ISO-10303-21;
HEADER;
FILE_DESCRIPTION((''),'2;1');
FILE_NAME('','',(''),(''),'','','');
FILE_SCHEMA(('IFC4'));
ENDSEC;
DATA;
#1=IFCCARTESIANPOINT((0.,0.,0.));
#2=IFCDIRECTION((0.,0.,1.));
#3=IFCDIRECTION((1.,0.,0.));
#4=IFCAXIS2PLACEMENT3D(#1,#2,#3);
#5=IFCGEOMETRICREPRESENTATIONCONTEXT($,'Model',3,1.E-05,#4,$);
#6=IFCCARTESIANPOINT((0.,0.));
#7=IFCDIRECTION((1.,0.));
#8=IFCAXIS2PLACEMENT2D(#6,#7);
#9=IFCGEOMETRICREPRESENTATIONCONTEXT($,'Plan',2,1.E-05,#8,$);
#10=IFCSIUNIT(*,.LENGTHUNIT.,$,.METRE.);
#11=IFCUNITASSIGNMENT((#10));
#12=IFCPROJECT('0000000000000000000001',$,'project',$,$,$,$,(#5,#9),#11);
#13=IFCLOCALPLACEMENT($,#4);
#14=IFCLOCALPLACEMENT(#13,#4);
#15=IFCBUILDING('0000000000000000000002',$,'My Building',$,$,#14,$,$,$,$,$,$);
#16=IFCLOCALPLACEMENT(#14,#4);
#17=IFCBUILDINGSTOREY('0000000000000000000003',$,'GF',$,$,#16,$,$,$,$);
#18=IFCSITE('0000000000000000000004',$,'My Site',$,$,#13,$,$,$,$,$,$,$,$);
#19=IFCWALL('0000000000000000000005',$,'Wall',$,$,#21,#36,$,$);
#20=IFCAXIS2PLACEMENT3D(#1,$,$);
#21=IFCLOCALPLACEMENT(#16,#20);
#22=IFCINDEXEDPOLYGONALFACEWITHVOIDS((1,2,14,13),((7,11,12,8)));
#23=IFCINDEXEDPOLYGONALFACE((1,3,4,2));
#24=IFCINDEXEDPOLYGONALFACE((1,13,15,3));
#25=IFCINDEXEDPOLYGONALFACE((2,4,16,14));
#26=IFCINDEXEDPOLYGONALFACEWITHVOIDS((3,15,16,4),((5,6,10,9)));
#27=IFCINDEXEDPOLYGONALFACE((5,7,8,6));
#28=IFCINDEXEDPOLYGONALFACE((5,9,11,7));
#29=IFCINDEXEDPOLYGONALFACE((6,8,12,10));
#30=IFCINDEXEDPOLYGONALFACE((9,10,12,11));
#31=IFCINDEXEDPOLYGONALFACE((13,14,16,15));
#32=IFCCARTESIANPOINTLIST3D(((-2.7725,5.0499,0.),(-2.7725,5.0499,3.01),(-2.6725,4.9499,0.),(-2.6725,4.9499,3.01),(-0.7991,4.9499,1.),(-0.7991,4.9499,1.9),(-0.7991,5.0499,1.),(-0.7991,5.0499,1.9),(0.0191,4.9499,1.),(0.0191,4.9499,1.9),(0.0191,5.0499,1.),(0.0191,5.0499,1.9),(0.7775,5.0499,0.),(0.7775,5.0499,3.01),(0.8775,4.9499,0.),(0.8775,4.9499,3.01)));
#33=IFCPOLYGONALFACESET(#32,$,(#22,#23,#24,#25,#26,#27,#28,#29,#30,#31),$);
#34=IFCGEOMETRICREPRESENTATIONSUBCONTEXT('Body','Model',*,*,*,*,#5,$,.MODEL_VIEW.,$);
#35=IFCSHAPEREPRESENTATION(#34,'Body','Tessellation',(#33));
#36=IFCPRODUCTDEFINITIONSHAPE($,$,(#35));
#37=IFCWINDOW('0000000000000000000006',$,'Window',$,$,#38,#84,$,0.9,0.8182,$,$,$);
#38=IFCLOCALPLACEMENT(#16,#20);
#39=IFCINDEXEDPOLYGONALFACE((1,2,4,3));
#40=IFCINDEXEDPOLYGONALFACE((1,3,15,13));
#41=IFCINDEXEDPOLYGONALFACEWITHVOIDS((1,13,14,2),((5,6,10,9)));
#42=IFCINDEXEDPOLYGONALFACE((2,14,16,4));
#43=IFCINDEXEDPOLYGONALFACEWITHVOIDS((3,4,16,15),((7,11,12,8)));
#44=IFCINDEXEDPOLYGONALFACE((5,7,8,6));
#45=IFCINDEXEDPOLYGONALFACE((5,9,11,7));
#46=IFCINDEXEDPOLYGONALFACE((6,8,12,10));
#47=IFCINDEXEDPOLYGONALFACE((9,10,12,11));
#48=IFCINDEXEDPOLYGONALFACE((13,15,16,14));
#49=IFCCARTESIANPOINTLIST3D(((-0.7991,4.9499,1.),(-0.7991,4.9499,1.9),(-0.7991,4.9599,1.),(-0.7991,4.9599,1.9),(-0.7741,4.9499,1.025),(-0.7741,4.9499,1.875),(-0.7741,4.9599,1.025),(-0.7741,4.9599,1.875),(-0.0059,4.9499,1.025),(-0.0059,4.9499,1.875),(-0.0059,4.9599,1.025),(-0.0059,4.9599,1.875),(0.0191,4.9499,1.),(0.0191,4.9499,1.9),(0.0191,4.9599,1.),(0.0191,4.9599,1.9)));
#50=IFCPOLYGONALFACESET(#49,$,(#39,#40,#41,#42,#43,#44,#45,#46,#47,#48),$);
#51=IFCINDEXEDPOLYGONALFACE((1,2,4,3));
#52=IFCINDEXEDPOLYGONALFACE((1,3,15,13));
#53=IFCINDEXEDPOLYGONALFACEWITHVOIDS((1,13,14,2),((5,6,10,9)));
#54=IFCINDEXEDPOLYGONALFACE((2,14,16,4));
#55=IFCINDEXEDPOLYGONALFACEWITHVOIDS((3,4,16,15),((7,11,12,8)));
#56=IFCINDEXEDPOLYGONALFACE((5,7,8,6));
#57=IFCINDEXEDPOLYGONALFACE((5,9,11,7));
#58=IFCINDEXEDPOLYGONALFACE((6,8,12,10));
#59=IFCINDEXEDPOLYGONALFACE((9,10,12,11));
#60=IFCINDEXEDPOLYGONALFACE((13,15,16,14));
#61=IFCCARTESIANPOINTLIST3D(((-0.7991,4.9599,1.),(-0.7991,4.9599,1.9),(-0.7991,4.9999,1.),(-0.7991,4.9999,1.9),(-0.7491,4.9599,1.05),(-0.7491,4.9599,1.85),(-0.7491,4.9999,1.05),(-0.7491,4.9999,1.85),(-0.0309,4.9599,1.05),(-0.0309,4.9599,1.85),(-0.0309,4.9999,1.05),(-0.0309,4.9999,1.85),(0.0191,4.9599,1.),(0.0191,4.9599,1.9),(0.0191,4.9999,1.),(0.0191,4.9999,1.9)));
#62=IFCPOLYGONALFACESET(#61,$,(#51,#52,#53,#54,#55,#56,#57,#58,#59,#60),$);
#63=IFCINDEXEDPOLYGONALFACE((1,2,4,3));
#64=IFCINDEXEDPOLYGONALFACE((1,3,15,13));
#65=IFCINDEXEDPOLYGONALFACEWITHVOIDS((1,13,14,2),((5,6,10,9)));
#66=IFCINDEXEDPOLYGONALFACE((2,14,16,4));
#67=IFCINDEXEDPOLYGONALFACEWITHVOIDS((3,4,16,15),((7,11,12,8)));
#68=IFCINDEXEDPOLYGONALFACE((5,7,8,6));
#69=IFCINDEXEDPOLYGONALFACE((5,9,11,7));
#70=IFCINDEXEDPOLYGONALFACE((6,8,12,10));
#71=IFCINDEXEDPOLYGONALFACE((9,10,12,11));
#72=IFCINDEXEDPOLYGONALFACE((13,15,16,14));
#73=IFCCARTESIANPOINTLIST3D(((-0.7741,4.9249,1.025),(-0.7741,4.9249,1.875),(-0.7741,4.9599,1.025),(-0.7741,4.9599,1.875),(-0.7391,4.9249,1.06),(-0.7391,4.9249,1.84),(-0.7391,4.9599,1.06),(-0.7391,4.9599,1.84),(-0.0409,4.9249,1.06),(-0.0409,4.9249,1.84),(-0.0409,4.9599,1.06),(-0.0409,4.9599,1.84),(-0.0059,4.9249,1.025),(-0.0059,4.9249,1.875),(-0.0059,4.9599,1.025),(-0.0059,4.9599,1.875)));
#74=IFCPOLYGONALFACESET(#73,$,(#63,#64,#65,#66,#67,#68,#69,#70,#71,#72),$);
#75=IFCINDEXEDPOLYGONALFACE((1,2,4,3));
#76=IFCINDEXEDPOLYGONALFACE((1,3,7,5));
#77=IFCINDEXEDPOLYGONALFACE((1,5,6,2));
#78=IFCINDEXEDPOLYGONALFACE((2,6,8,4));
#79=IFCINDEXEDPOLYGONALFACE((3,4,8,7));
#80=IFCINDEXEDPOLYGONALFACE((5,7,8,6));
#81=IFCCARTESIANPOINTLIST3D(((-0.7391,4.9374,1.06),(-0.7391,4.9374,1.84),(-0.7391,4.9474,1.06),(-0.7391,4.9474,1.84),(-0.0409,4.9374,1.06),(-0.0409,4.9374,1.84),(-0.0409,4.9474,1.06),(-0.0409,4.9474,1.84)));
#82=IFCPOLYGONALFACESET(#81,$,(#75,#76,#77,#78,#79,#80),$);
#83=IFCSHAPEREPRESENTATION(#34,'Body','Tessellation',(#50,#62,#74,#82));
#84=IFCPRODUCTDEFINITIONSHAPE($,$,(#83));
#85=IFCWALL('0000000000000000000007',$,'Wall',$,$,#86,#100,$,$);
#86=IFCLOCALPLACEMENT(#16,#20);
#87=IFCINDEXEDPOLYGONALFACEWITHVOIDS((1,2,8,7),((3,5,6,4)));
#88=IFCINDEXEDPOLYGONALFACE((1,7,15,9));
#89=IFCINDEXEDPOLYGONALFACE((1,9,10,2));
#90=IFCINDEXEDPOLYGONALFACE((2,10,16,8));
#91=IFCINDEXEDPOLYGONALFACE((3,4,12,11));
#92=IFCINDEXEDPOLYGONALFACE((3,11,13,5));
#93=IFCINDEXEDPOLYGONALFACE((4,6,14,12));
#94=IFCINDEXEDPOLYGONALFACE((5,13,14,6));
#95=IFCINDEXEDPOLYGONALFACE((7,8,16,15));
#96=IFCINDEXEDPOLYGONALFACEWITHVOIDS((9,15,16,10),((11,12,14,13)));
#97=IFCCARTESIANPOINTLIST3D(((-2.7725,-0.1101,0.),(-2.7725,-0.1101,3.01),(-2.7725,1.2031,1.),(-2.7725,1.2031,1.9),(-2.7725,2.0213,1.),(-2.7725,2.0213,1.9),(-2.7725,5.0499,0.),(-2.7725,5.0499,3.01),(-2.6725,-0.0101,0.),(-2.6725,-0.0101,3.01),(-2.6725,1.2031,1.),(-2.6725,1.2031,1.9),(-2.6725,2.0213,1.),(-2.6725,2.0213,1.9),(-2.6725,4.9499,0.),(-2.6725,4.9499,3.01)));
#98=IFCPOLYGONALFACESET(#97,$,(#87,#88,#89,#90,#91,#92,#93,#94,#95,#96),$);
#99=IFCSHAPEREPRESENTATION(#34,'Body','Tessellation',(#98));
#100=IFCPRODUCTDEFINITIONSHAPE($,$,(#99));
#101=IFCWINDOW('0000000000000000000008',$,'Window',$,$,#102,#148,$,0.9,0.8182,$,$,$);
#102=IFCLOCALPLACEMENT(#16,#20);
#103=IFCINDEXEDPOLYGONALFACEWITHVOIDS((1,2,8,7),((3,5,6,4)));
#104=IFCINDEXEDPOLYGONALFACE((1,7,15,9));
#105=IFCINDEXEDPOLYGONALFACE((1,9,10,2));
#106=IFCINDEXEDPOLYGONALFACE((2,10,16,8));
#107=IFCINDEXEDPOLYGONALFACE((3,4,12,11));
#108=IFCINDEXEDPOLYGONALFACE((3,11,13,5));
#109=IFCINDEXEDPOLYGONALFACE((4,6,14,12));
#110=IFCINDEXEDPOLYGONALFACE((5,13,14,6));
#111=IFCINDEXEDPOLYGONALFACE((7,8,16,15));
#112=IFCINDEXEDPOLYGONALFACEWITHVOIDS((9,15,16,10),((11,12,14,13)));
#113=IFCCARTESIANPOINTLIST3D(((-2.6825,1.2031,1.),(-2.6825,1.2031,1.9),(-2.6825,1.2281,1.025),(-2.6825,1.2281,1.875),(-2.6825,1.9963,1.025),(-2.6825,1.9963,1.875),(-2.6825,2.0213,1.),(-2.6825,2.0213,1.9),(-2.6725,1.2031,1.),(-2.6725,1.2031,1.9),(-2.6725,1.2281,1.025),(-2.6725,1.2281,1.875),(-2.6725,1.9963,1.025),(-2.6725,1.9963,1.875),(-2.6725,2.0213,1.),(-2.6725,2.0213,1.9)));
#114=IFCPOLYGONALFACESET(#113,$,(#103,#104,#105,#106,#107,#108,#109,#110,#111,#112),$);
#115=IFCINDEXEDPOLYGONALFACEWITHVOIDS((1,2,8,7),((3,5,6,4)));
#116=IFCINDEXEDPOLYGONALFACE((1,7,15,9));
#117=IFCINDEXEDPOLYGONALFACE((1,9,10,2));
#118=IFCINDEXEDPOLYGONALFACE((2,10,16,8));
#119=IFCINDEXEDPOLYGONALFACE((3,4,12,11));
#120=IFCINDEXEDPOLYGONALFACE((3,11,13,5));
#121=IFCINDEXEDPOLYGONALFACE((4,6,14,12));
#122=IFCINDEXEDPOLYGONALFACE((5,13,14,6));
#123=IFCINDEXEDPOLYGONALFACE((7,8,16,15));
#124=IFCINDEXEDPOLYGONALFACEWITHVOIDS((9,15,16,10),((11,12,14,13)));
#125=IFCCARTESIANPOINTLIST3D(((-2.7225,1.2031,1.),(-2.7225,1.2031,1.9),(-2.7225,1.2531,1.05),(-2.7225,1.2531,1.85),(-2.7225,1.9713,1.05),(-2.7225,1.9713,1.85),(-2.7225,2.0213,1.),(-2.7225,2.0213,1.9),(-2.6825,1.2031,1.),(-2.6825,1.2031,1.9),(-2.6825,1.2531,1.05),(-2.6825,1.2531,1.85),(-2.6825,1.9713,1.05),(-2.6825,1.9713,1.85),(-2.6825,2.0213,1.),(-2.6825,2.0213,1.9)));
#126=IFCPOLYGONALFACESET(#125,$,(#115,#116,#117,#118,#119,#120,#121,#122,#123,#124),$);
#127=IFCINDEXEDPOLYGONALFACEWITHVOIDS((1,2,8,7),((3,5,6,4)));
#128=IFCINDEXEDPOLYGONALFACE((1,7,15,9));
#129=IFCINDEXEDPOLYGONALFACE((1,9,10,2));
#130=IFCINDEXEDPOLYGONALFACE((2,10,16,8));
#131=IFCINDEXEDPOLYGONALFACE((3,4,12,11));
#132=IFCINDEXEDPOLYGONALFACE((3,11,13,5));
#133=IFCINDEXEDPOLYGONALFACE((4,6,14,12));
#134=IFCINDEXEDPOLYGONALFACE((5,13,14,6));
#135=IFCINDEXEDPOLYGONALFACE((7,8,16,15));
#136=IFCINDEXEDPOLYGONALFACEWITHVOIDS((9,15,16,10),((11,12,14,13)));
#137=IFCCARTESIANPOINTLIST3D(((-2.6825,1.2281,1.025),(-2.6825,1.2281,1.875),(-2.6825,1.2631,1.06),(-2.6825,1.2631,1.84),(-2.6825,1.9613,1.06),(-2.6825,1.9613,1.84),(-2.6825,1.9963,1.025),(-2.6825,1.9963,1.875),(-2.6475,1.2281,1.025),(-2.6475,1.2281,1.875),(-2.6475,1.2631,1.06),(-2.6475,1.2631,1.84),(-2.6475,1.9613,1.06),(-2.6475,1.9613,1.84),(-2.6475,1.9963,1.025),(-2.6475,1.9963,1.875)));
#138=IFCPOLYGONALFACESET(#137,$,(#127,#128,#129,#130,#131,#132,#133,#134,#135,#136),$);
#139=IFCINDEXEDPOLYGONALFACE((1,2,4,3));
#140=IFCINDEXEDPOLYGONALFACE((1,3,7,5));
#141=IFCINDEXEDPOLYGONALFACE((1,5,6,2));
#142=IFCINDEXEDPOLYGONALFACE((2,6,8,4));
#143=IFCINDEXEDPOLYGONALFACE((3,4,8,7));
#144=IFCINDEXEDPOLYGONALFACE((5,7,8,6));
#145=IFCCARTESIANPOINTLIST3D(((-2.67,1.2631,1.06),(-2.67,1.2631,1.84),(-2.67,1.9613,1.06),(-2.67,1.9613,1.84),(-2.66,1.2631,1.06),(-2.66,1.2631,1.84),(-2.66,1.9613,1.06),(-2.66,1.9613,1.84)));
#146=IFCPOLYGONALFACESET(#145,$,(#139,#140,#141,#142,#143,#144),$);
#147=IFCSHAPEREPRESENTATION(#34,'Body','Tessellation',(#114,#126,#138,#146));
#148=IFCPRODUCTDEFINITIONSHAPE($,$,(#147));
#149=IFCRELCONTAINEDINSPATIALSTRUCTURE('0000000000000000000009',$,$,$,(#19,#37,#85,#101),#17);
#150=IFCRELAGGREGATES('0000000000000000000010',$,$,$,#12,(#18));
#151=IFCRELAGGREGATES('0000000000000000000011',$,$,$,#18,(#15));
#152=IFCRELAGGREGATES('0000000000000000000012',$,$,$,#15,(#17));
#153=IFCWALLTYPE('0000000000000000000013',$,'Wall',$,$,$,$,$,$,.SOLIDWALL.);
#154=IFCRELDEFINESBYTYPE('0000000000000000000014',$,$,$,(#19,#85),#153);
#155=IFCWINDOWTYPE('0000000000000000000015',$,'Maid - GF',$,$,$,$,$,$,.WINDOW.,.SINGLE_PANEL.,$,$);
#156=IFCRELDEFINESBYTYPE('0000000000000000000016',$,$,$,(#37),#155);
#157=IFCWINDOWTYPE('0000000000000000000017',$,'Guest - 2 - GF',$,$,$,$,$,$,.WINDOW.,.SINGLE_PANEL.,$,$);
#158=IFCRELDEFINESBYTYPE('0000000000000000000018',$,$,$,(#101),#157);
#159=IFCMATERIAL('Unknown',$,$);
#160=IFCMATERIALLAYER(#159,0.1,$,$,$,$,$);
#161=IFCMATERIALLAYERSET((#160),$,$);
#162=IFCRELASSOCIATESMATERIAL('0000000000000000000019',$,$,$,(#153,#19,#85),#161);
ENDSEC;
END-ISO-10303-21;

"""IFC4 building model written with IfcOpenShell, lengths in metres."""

from ifc_helpers import new_model, entity, si_unit, frame, origin_with_axes, origin_2d_with_axis, place, context, subcontext, project, spatial, line, indexed_curve, outline, extrude, shape, source, transform, mapped, material, layer, layer_set, layer_usage, type_object, type_shapes, element, fill, save


model = new_model("IFC4")

# Units and contexts
model_context = context("Model", 3, precision=1e-05, world=origin_with_axes())
plan_context = context("Plan", 2, precision=1e-05, world=origin_2d_with_axis())
body_context_1 = subcontext(model_context, "Body", "Model", "MODEL_VIEW")
body_context_2 = subcontext(plan_context, "Body", "Plan", "PLAN_VIEW")
ifc_project = project(units=[si_unit("LENGTHUNIT", "METRE")], contexts=[model_context, plan_context])

# Site, building, storey
site_placement = place(None, origin_with_axes())
site = spatial("IfcSite", under=ifc_project, at=site_placement, Name="My Site")
building_placement = place(site_placement, origin_with_axes())
building = spatial("IfcBuilding", under=site, at=building_placement, Name="My Building")
storey_placement = place(building_placement, origin_with_axes())
storey = spatial("IfcBuildingStorey", under=building, at=storey_placement, Name="GF")

# Shared definitions
ifc_material_1 = material(Name="Unknown")

# Shared definitions
ifc_layer_1 = layer(ifc_material_1, 0.1)
ifc_layer_set_1 = layer_set([ifc_layer_1])
wall_type = type_object("IfcWallType", Name="Wall", PredefinedType="SOLIDWALL", material=ifc_layer_set_1)

# Walls, openings, windows
ifc_layer_usage_1 = layer_usage(ifc_layer_set_1, "AXIS2", "POSITIVE", 0.0)
wall_1_placement = place(storey_placement, frame((0.7775, 5.0499, 0.0), z_axis=(0.0, 0.0, 1.0), x_axis=(-1.0, 0.0, 0.0)))
wall_1 = element("IfcWall", 1, at=wall_1_placement, inside=storey, type_object=wall_type, material=ifc_layer_usage_1, Name="Wall", context=body_context_1, shape_type="SweptSolid", body=[
    extrude(outline(indexed_curve([(0.0, 0.0), (-0.1, 0.1), (3.45, 0.1), (3.55, 0.0)], segments=[line(1, 2, 3, 4, 1)])), origin_with_axes(), (0.0, 0.0, 1.0), 3.01),
])
shared_shape_1 = source(origin_with_axes(), body_context_1, "Body", "SweptSolid", [
    extrude(outline(indexed_curve([(0.0, 0.0), (0.8182, 0.0), (0.8182, 0.9), (0.0, 0.9)], segments=[line(1, 2, 3, 4, 1)])), frame((0.0, -0.6, 0.0), z_axis=(0.0, -1.0, 0.0), x_axis=(1.0, 0.0, 0.0)), (0.0, 0.0, -1.0), 1.2),
])
opening_1_placement = place(wall_1_placement, frame((0.7584, 0.0, 1.0), z_axis=(0.0, 0.0, 1.0), x_axis=(1.0, 0.0, 0.0)))
opening_1 = element("IfcOpeningElement", 2, at=opening_1_placement, cuts=wall_1, PredefinedType="OPENING", context=body_context_1, shape_type="MappedRepresentation", body=[
    mapped(shared_shape_1, transform((0.0, 0.0, 0.0), x_axis=(1.0, 0.0, 0.0), y_axis=(0.0, 1.0, 0.0), z_axis=(0.0, 0.0, 1.0), scale=1.0)),
])
window_type_1 = type_object("IfcWindowType", Name="Maid - GF", PartitioningType="SINGLE_PANEL", PredefinedType="WINDOW")
shared_shape_2 = source(origin_with_axes(), body_context_1, "Body", "SweptSolid", [
    extrude(outline(indexed_curve([(0.0, 0.0), (0.8182, 0.0), (0.8182, 0.9), (0.0, 0.9)], segments=[line(1, 2, 3, 4, 1)]), holes=[indexed_curve([(0.025, 0.025), (0.7932, 0.025), (0.7932, 0.875), (0.025, 0.875)], segments=[line(1, 2, 3, 4, 1)])]), frame((0.0, 0.09, 0.0), z_axis=(0.0, -1.0, 0.0), x_axis=(1.0, 0.0, 0.0)), (0.0, 0.0, -1.0), 0.01),
    extrude(outline(indexed_curve([(0.0, 0.0), (0.8182, 0.0), (0.8182, 0.9), (0.0, 0.9)], segments=[line(1, 2, 3, 4, 1)]), holes=[indexed_curve([(0.05, 0.05), (0.7682, 0.05), (0.7682, 0.85), (0.05, 0.85)], segments=[line(1, 2, 3, 4, 1)])]), frame((0.0, 0.05, 0.0), z_axis=(0.0, -1.0, 0.0), x_axis=(1.0, 0.0, 0.0)), (0.0, 0.0, -1.0), 0.04),
    extrude(outline(indexed_curve([(0.0, 0.0), (0.7682, 0.0), (0.7682, 0.85), (0.0, 0.85)], segments=[line(1, 2, 3, 4, 1)]), holes=[indexed_curve([(0.035, 0.035), (0.7332, 0.035), (0.7332, 0.815), (0.035, 0.815)], segments=[line(1, 2, 3, 4, 1)])]), frame((0.025, 0.09, 0.025), z_axis=(0.0, -1.0, 0.0), x_axis=(1.0, 0.0, 0.0)), (0.0, 0.0, -1.0), 0.035),
    extrude(outline(indexed_curve([(0.035, 0.035), (0.7332, 0.035), (0.7332, 0.815), (0.035, 0.815)], segments=[line(1, 2, 3, 4, 1)])), frame((0.025, 0.1025, 0.025), z_axis=(0.0, -1.0, 0.0), x_axis=(1.0, 0.0, 0.0)), (0.0, 0.0, -1.0), 0.01),
])
shared_shape_3 = source(origin_with_axes(), body_context_2, "Body", "Curve2D", [
    entity("IfcIndexedPolyCurve", entity("IfcCartesianPointList2D", [[0.05, 0.05], [0.7682, 0.05]])),
    entity("IfcIndexedPolyCurve", entity("IfcCartesianPointList2D", [[0.0, 0.1], [0.025, 0.1], [0.025, 0.09], [0.05, 0.09], [0.05, 0.05], [0.0, 0.05]]), [entity("IfcLineIndex", [1, 2, 3, 4, 5, 6, 1])]),
    entity("IfcIndexedPolyCurve", entity("IfcCartesianPointList2D", [[0.8182, 0.1], [0.7932, 0.1], [0.7932, 0.09], [0.7682, 0.09], [0.7682, 0.05], [0.8182, 0.05]]), [entity("IfcLineIndex", [1, 2, 3, 4, 5, 6, 1])]),
    entity("IfcIndexedPolyCurve", entity("IfcCartesianPointList2D", [[0.025, 0.09], [0.06, 0.09], [0.06, 0.125], [0.025, 0.125]]), [entity("IfcLineIndex", [1, 2, 3, 4, 1])]),
    entity("IfcIndexedPolyCurve", entity("IfcCartesianPointList2D", [[0.7932, 0.09], [0.7582, 0.09], [0.7582, 0.125], [0.7932, 0.125]]), [entity("IfcLineIndex", [1, 2, 3, 4, 1])]),
    entity("IfcIndexedPolyCurve", entity("IfcCartesianPointList2D", [[0.06, 0.09], [0.7582, 0.09]])),
    entity("IfcIndexedPolyCurve", entity("IfcCartesianPointList2D", [[0.06, 0.125], [0.7582, 0.125]])),
    entity("IfcIndexedPolyCurve", entity("IfcCartesianPointList2D", [[0.06, 0.1075], [0.7582, 0.1075]])),
])
type_shapes(window_type_1, [shared_shape_2, shared_shape_3])
window_1_placement = place(opening_1_placement, frame((0.0, 0.0, 0.0), z_axis=(0.0, 0.0, 1.0), x_axis=(1.0, 0.0, 0.0)))
window_1 = element("IfcWindow", 3, at=window_1_placement, inside=storey, type_object=window_type_1, Name="Window", OverallHeight=0.9, OverallWidth=0.8182, shapes=[
    shape(body_context_1, "Body", "MappedRepresentation", [mapped(shared_shape_2, transform((0.0, 0.0, 0.0), x_axis=(1.0, 0.0, 0.0), y_axis=(0.0, 1.0, 0.0), z_axis=(0.0, 0.0, 1.0), scale=1.0))]),
    shape(body_context_2, "Body", "MappedRepresentation", [mapped(shared_shape_3, transform((0.0, 0.0, 0.0), x_axis=(1.0, 0.0, 0.0), y_axis=(0.0, 1.0, 0.0), z_axis=(0.0, 0.0, 1.0), scale=1.0))]),
])
fill(opening_1, window_1)
ifc_layer_usage_2 = layer_usage(ifc_layer_set_1, "AXIS2", "POSITIVE", 0.0)
wall_2_placement = place(storey_placement, frame((-2.7725, 5.0499, 0.0), z_axis=(0.0, 0.0, 1.0), x_axis=(0.0, -1.0, 0.0)))
wall_2 = element("IfcWall", 4, at=wall_2_placement, inside=storey, type_object=wall_type, material=ifc_layer_usage_2, Name="Wall", context=body_context_1, shape_type="SweptSolid", body=[
    extrude(outline(indexed_curve([(0.0, 0.0), (0.1, 0.1), (5.06, 0.1), (5.16, 0.0)], segments=[line(1, 2, 3, 4, 1)])), origin_with_axes(), (0.0, 0.0, 1.0), 3.01),
])
shared_shape_4 = source(origin_with_axes(), body_context_1, "Body", "SweptSolid", [
    extrude(outline(indexed_curve([(0.0, 0.0), (0.8182, 0.0), (0.8182, 0.9), (0.0, 0.9)], segments=[line(1, 2, 3, 4, 1)])), frame((0.0, -0.6, 0.0), z_axis=(0.0, -1.0, 0.0), x_axis=(1.0, 0.0, 0.0)), (0.0, 0.0, -1.0), 1.2),
])
opening_2_placement = place(wall_2_placement, frame((3.0286, 0.0, 1.0), z_axis=(0.0, 0.0, 1.0), x_axis=(1.0, 0.0, 0.0)))
opening_2 = element("IfcOpeningElement", 5, at=opening_2_placement, cuts=wall_2, PredefinedType="OPENING", context=body_context_1, shape_type="MappedRepresentation", body=[
    mapped(shared_shape_4, transform((0.0, 0.0, 0.0), x_axis=(1.0, 0.0, 0.0), y_axis=(0.0, 1.0, 0.0), z_axis=(0.0, 0.0, 1.0), scale=1.0)),
])
window_type_2 = type_object("IfcWindowType", Name="Guest - 2 - GF", PartitioningType="SINGLE_PANEL", PredefinedType="WINDOW")
shared_shape_5 = source(origin_with_axes(), body_context_1, "Body", "SweptSolid", [
    extrude(outline(indexed_curve([(0.0, 0.0), (0.8182, 0.0), (0.8182, 0.9), (0.0, 0.9)], segments=[line(1, 2, 3, 4, 1)]), holes=[indexed_curve([(0.025, 0.025), (0.7932, 0.025), (0.7932, 0.875), (0.025, 0.875)], segments=[line(1, 2, 3, 4, 1)])]), frame((0.0, 0.09, 0.0), z_axis=(0.0, -1.0, 0.0), x_axis=(1.0, 0.0, 0.0)), (0.0, 0.0, -1.0), 0.01),
    extrude(outline(indexed_curve([(0.0, 0.0), (0.8182, 0.0), (0.8182, 0.9), (0.0, 0.9)], segments=[line(1, 2, 3, 4, 1)]), holes=[indexed_curve([(0.05, 0.05), (0.7682, 0.05), (0.7682, 0.85), (0.05, 0.85)], segments=[line(1, 2, 3, 4, 1)])]), frame((0.0, 0.05, 0.0), z_axis=(0.0, -1.0, 0.0), x_axis=(1.0, 0.0, 0.0)), (0.0, 0.0, -1.0), 0.04),
    extrude(outline(indexed_curve([(0.0, 0.0), (0.7682, 0.0), (0.7682, 0.85), (0.0, 0.85)], segments=[line(1, 2, 3, 4, 1)]), holes=[indexed_curve([(0.035, 0.035), (0.7332, 0.035), (0.7332, 0.815), (0.035, 0.815)], segments=[line(1, 2, 3, 4, 1)])]), frame((0.025, 0.09, 0.025), z_axis=(0.0, -1.0, 0.0), x_axis=(1.0, 0.0, 0.0)), (0.0, 0.0, -1.0), 0.035),
    extrude(outline(indexed_curve([(0.035, 0.035), (0.7332, 0.035), (0.7332, 0.815), (0.035, 0.815)], segments=[line(1, 2, 3, 4, 1)])), frame((0.025, 0.1025, 0.025), z_axis=(0.0, -1.0, 0.0), x_axis=(1.0, 0.0, 0.0)), (0.0, 0.0, -1.0), 0.01),
])
shared_shape_6 = source(origin_with_axes(), body_context_2, "Body", "Curve2D", [
    entity("IfcIndexedPolyCurve", entity("IfcCartesianPointList2D", [[0.05, 0.05], [0.7682, 0.05]])),
    entity("IfcIndexedPolyCurve", entity("IfcCartesianPointList2D", [[0.0, 0.1], [0.025, 0.1], [0.025, 0.09], [0.05, 0.09], [0.05, 0.05], [0.0, 0.05]]), [entity("IfcLineIndex", [1, 2, 3, 4, 5, 6, 1])]),
    entity("IfcIndexedPolyCurve", entity("IfcCartesianPointList2D", [[0.8182, 0.1], [0.7932, 0.1], [0.7932, 0.09], [0.7682, 0.09], [0.7682, 0.05], [0.8182, 0.05]]), [entity("IfcLineIndex", [1, 2, 3, 4, 5, 6, 1])]),
    entity("IfcIndexedPolyCurve", entity("IfcCartesianPointList2D", [[0.025, 0.09], [0.06, 0.09], [0.06, 0.125], [0.025, 0.125]]), [entity("IfcLineIndex", [1, 2, 3, 4, 1])]),
    entity("IfcIndexedPolyCurve", entity("IfcCartesianPointList2D", [[0.7932, 0.09], [0.7582, 0.09], [0.7582, 0.125], [0.7932, 0.125]]), [entity("IfcLineIndex", [1, 2, 3, 4, 1])]),
    entity("IfcIndexedPolyCurve", entity("IfcCartesianPointList2D", [[0.06, 0.09], [0.7582, 0.09]])),
    entity("IfcIndexedPolyCurve", entity("IfcCartesianPointList2D", [[0.06, 0.125], [0.7582, 0.125]])),
    entity("IfcIndexedPolyCurve", entity("IfcCartesianPointList2D", [[0.06, 0.1075], [0.7582, 0.1075]])),
])
type_shapes(window_type_2, [shared_shape_5, shared_shape_6])
window_2_placement = place(opening_2_placement, frame((0.0, 0.0, 0.0), z_axis=(0.0, 0.0, 1.0), x_axis=(1.0, 0.0, 0.0)))
window_2 = element("IfcWindow", 6, at=window_2_placement, inside=storey, type_object=window_type_2, Name="Window", OverallHeight=0.9, OverallWidth=0.8182, shapes=[
    shape(body_context_1, "Body", "MappedRepresentation", [mapped(shared_shape_5, transform((0.0, 0.0, 0.0), x_axis=(1.0, 0.0, 0.0), y_axis=(0.0, 1.0, 0.0), z_axis=(0.0, 0.0, 1.0), scale=1.0))]),
    shape(body_context_2, "Body", "MappedRepresentation", [mapped(shared_shape_6, transform((0.0, 0.0, 0.0), x_axis=(1.0, 0.0, 0.0), y_axis=(0.0, 1.0, 0.0), z_axis=(0.0, 0.0, 1.0), scale=1.0))]),
])
fill(opening_2, window_2)

save(model, "model.ifc")
